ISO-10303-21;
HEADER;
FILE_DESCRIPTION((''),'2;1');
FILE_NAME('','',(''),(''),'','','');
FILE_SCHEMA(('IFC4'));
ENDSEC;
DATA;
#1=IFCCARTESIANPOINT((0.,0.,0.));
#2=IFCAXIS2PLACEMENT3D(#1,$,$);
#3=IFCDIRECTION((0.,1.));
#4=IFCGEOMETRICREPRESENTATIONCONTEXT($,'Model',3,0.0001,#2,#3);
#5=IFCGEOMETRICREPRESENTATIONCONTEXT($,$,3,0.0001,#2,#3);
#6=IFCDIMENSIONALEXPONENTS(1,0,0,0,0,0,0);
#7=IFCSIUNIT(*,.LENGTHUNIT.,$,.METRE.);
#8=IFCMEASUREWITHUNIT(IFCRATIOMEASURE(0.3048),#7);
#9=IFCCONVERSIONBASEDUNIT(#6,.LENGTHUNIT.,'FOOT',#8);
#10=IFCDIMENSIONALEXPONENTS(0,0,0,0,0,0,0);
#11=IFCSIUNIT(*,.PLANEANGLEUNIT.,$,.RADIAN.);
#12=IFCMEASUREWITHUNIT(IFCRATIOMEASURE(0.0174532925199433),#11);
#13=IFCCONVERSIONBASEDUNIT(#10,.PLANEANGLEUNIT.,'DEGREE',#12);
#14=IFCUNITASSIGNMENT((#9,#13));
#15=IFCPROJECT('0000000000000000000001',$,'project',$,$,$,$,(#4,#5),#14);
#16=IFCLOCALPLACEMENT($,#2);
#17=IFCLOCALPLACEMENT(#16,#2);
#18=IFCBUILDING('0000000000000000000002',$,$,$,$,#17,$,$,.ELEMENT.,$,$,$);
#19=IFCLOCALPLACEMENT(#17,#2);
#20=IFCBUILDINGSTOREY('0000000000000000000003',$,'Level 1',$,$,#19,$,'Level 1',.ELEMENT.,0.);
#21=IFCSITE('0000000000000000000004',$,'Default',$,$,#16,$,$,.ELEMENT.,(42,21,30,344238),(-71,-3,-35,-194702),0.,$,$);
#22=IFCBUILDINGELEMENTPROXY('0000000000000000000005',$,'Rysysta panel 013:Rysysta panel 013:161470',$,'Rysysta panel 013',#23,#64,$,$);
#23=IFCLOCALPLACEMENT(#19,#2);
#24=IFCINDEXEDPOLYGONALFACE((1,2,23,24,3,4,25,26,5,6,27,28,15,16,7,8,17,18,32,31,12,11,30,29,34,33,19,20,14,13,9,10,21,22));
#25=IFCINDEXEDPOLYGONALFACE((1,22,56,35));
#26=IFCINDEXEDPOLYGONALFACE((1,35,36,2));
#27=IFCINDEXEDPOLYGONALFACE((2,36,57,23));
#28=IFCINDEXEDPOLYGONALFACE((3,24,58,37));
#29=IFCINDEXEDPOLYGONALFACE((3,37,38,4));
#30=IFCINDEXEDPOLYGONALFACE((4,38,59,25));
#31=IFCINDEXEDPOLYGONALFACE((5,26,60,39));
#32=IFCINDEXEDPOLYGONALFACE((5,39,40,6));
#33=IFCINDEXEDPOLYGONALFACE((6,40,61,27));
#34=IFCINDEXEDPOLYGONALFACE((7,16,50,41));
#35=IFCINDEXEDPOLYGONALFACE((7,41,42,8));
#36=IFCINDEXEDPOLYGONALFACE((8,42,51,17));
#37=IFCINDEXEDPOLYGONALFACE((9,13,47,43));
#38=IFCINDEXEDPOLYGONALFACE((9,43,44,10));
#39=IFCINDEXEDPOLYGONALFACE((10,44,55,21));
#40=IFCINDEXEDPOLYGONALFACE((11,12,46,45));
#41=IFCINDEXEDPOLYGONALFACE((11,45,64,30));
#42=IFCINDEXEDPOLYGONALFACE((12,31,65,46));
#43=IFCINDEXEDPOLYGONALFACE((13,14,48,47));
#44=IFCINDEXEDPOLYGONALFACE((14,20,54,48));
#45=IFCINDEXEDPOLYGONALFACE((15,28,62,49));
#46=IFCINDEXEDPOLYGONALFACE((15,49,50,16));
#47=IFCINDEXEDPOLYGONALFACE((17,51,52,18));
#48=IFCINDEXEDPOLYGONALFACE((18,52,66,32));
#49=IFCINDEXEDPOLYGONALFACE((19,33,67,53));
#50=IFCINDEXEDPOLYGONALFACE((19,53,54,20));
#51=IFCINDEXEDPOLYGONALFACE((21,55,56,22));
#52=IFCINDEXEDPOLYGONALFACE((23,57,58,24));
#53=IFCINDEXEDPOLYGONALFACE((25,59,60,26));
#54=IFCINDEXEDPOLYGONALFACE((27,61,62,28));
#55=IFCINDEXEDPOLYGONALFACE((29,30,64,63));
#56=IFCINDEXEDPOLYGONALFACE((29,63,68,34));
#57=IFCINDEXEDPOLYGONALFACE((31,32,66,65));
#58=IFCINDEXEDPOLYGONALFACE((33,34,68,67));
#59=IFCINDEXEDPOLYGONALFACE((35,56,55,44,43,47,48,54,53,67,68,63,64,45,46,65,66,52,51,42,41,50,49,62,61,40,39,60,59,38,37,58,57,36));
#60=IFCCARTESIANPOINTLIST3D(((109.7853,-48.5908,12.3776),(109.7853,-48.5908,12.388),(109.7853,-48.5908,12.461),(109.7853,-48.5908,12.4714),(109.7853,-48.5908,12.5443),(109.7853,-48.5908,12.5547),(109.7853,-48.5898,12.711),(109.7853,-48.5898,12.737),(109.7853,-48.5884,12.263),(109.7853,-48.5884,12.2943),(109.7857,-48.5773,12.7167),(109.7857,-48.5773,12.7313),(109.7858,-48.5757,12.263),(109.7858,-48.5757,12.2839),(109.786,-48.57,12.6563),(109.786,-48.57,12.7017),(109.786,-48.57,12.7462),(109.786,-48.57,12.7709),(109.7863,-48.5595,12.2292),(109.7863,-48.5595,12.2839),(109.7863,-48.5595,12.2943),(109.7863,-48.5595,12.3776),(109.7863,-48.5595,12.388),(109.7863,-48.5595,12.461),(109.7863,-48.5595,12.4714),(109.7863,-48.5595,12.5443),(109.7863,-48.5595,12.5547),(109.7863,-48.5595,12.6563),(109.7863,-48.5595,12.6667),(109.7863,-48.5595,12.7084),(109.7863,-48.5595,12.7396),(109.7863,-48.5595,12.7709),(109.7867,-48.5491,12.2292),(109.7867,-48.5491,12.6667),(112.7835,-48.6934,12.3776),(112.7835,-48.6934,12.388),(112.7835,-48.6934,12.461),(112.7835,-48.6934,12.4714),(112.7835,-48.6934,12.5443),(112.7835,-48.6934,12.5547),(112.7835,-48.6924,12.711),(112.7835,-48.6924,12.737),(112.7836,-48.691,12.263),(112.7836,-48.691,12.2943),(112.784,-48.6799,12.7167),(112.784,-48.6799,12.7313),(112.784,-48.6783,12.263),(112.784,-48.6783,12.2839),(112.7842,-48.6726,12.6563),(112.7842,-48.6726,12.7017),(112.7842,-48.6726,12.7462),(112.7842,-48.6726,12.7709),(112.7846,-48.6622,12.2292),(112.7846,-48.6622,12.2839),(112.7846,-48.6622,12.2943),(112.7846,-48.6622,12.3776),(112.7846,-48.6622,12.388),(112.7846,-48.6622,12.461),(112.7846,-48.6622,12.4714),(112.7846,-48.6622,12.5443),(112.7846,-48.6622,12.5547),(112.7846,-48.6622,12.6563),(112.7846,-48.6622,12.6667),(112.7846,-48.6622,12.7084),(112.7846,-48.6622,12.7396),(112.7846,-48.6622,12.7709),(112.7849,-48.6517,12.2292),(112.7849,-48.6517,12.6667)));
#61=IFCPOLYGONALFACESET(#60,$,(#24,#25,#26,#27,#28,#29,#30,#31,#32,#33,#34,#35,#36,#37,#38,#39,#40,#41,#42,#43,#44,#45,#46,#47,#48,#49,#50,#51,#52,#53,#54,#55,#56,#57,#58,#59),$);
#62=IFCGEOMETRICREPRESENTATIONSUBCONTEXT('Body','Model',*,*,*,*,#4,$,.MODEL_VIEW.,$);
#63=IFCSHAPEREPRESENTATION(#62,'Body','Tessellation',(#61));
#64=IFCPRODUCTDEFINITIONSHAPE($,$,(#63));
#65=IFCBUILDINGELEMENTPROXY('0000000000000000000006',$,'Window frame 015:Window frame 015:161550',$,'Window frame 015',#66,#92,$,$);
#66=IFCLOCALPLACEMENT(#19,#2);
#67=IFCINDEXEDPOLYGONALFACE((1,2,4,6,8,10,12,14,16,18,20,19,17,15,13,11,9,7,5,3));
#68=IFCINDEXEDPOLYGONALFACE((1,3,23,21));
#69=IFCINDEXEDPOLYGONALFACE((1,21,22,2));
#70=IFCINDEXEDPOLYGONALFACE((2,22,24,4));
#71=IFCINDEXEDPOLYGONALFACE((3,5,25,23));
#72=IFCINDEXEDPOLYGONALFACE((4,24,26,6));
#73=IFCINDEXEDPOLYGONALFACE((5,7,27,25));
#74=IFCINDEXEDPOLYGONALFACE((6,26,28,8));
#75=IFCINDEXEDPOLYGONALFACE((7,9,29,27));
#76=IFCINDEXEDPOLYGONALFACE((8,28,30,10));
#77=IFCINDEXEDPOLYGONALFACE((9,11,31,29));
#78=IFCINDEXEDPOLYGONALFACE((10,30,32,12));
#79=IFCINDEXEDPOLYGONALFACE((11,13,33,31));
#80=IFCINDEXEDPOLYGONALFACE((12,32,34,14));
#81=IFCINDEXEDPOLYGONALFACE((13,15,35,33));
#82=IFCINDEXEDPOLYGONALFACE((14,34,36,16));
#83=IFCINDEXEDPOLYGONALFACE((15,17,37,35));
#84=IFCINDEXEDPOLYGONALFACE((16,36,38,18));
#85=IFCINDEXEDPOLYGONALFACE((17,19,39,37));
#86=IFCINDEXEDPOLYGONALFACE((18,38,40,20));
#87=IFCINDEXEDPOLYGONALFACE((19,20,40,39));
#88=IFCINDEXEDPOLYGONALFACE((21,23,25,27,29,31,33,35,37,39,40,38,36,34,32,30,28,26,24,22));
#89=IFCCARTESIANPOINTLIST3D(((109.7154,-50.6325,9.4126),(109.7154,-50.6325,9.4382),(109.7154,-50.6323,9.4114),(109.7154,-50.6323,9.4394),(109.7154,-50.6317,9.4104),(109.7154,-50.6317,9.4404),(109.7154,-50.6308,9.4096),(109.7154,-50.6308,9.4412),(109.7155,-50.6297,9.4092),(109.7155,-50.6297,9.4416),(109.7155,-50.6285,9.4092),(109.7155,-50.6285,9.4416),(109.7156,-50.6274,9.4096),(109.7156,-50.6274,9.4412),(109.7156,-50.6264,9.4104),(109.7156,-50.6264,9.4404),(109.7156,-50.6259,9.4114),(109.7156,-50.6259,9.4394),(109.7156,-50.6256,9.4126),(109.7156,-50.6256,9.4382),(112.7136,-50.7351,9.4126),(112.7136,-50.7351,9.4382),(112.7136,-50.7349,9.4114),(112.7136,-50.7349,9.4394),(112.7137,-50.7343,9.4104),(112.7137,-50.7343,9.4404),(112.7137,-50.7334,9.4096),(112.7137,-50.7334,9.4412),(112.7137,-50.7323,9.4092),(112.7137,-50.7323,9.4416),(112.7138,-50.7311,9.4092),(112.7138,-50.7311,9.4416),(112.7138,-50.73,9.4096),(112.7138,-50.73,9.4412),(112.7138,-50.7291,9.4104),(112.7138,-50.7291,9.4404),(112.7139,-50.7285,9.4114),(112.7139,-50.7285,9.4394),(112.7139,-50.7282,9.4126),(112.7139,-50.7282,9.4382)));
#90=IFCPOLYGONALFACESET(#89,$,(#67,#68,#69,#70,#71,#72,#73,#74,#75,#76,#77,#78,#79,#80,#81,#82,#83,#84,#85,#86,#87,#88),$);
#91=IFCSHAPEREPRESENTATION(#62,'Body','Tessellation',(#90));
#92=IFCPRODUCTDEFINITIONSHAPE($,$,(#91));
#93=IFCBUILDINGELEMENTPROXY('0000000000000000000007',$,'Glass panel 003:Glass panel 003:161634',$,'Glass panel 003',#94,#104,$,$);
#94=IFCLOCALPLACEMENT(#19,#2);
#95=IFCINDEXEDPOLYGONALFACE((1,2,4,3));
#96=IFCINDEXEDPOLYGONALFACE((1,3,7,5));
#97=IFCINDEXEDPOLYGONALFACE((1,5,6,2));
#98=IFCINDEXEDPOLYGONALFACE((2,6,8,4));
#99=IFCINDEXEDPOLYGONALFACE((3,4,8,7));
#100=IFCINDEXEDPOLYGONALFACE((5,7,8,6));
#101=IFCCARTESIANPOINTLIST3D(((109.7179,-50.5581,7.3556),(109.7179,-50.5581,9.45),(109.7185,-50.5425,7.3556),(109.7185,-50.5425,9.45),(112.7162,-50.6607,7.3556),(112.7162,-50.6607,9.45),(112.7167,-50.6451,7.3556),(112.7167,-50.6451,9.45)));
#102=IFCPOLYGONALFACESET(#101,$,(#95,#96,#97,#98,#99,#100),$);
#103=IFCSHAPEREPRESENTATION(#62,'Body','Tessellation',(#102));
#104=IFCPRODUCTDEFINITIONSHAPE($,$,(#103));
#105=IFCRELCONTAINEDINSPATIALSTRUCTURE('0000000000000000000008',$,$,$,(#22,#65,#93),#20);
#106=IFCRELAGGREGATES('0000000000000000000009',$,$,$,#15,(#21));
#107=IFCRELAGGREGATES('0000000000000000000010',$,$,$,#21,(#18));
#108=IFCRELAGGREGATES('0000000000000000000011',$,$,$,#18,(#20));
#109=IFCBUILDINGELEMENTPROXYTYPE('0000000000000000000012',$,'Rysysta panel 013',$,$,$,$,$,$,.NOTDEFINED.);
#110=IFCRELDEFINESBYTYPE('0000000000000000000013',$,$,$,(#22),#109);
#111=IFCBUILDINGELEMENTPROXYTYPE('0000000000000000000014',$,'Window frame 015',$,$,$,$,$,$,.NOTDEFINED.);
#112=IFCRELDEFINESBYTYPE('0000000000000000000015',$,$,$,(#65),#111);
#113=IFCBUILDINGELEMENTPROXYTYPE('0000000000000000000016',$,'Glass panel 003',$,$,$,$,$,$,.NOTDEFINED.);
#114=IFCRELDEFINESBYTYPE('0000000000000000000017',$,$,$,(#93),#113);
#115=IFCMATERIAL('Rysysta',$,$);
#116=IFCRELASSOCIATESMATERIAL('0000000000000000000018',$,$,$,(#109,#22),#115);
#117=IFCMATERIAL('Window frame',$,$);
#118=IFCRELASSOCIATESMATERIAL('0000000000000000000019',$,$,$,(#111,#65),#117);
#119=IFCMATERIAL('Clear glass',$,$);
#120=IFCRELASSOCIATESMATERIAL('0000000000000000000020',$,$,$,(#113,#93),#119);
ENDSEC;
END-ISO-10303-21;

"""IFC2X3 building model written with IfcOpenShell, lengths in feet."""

from ifc_helpers import new_model, entity, si_unit, converted_unit, direction, frame, frame_2d, origin, place, context, subcontext, project, spatial, polyline, circle_curve, parameter, trimmed, segment, composite_curve, rectangle, outline, extrude, source, transform, mapped, material, type_object, type_shapes, element, save


model = new_model("IFC2X3")

# Units and contexts
model_context = context("Model", 3, precision=0.0001, world=origin(), true_north=direction((0.0, 1.0)))
context_of_model = context(None, 3, precision=0.0001, world=origin(), true_north=direction((0.0, 1.0)))
body_context = subcontext(model_context, "Body", "Model", "MODEL_VIEW")
ifc_project = project(units=[converted_unit("LENGTHUNIT", "FOOT", entity("IfcRatioMeasure", 0.3048), si_unit("LENGTHUNIT", "METRE"), dimensions=[1, 0, 0, 0, 0, 0, 0]), converted_unit("PLANEANGLEUNIT", "DEGREE", entity("IfcRatioMeasure", 0.0174532925199433), si_unit("PLANEANGLEUNIT", "RADIAN"), dimensions=[0, 0, 0, 0, 0, 0, 0])], contexts=[model_context, context_of_model])

# Site, building, storey
site_placement = place(None, origin())
site = spatial("IfcSite", under=ifc_project, at=site_placement, Name="Default", CompositionType="ELEMENT", RefLatitude=(42, 21, 30, 344238), RefLongitude=(-71, -3, -35, -194702), RefElevation=0.0)
building_placement = place(site_placement, origin())
building = spatial("IfcBuilding", under=site, at=building_placement, CompositionType="ELEMENT")
storey_placement = place(building_placement, origin())
storey = spatial("IfcBuildingStorey", under=building, at=storey_placement, Name="Level 1", LongName="Level 1", CompositionType="ELEMENT", Elevation=0.0)

# Building element proxies
ifc_material_1 = material(Name="Window frame")
ifc_material_2 = material(Name="Rysysta")
ifc_material_3 = material(Name="Clear glass")
building_element_proxy_type_1 = type_object("IfcBuildingElementProxyType", Name="Rysysta panel 013", PredefinedType="NOTDEFINED", material=ifc_material_2)
shared_shape_1 = source(origin(), body_context, "Body", "SweptSolid", [
    extrude(outline(polyline([(-0.022, 0.1457), (-0.022, -0.2918), (-0.0116, -0.2918), (-0.0116, -0.2371), (0.0045, -0.2371), (0.0045, -0.258), (0.0173, -0.258), (0.0173, -0.2267), (-0.0116, -0.2267), (-0.0116, -0.1434), (0.0196, -0.1434), (0.0196, -0.133), (-0.0116, -0.133), (-0.0116, -0.06), (0.0196, -0.06), (0.0196, -0.0496), (-0.0116, -0.0496), (-0.0116, 0.0233), (0.0196, 0.0233), (0.0196, 0.0337), (-0.0116, 0.0337), (-0.0116, 0.1353), (-0.0012, 0.1353), (-0.0012, 0.1807), (0.0186, 0.1899), (0.0186, 0.216), (-0.0012, 0.2252), (-0.0012, 0.2498), (-0.0116, 0.2498), (-0.0116, 0.2186), (0.0062, 0.2103), (0.0062, 0.1956), (-0.0116, 0.1873), (-0.0116, 0.1457), (-0.022, 0.1457)])), frame((109.7859, -48.5711, 12.521), z_axis=(-0.999415, 0.034202, 0.0), x_axis=(-0.034202, -0.999415, 0.0)), (0.0, 0.0, -1.0), 3.0),
])
type_shapes(building_element_proxy_type_1, [shared_shape_1])
proxy_1_placement = place(storey_placement, origin())
element("IfcBuildingElementProxy", 1, at=proxy_1_placement, inside=storey, type_object=building_element_proxy_type_1, material=ifc_material_2, Name="Rysysta panel 013:Rysysta panel 013:161470", ObjectType="Rysysta panel 013", context=body_context, shape_type="MappedRepresentation", body=[
    mapped(shared_shape_1, transform((0.0, 0.0, 0.0), scale=1.0)),
])
building_element_proxy_type_2 = type_object("IfcBuildingElementProxyType", Name="Window frame 015", PredefinedType="NOTDEFINED", material=ifc_material_1)
shared_shape_2 = source(origin(), body_context, "Body", "SweptSolid", [
    extrude(outline(composite_curve([segment(trimmed(circle_curve(frame_2d((0.0, 0.0128), x_axis=(1.0, 0.0)), 0.0034), [parameter(0.0)], [parameter(180.0)], True, "PARAMETER"), True, "CONTINUOUS"), segment(polyline([(-0.0034, 0.0128), (-0.0034, -0.0128)]), True, "CONTINUOUS"), segment(trimmed(circle_curve(frame_2d((0.0, -0.0128), x_axis=(1.0, 0.0)), 0.0034), [parameter(180.0)], [parameter(0.0)], True, "PARAMETER"), True, "CONTINUOUS"), segment(polyline([(0.0034, -0.0128), (0.0034, 0.0128)]), True, "CONTINUOUS")], self_intersect=False)), frame((109.7155, -50.6291, 9.4254), z_axis=(0.999415, -0.034202, 0.0), x_axis=(-0.034202, -0.999415, 0.0)), (0.0, 0.0, 1.0), 3.0),
])
type_shapes(building_element_proxy_type_2, [shared_shape_2])
proxy_2_placement = place(storey_placement, origin())
element("IfcBuildingElementProxy", 2, at=proxy_2_placement, inside=storey, type_object=building_element_proxy_type_2, material=ifc_material_1, Name="Window frame 015:Window frame 015:161550", ObjectType="Window frame 015", context=body_context, shape_type="MappedRepresentation", body=[
    mapped(shared_shape_2, transform((0.0, 0.0, 0.0), scale=1.0)),
])
building_element_proxy_type_3 = type_object("IfcBuildingElementProxyType", Name="Glass panel 003", PredefinedType="NOTDEFINED", material=ifc_material_3)
shared_shape_3 = source(origin(), body_context, "Body", "SweptSolid", [
    extrude(rectangle(XDim=3.0, YDim=0.0156, at=frame_2d((0.0, 0.0), x_axis=(1.0, 0.0))), frame((111.2173, -50.6016, 7.3556), z_axis=(0.0, 0.0, 1.0), x_axis=(-0.999415, 0.034202, 0.0)), (0.0, 0.0, 1.0), 2.0943),
])
type_shapes(building_element_proxy_type_3, [shared_shape_3])
proxy_3_placement = place(storey_placement, origin())
element("IfcBuildingElementProxy", 3, at=proxy_3_placement, inside=storey, type_object=building_element_proxy_type_3, material=ifc_material_3, Name="Glass panel 003:Glass panel 003:161634", ObjectType="Glass panel 003", context=body_context, shape_type="MappedRepresentation", body=[
    mapped(shared_shape_3, transform((0.0, 0.0, 0.0), scale=1.0)),
])

save(model, "model.ifc")
